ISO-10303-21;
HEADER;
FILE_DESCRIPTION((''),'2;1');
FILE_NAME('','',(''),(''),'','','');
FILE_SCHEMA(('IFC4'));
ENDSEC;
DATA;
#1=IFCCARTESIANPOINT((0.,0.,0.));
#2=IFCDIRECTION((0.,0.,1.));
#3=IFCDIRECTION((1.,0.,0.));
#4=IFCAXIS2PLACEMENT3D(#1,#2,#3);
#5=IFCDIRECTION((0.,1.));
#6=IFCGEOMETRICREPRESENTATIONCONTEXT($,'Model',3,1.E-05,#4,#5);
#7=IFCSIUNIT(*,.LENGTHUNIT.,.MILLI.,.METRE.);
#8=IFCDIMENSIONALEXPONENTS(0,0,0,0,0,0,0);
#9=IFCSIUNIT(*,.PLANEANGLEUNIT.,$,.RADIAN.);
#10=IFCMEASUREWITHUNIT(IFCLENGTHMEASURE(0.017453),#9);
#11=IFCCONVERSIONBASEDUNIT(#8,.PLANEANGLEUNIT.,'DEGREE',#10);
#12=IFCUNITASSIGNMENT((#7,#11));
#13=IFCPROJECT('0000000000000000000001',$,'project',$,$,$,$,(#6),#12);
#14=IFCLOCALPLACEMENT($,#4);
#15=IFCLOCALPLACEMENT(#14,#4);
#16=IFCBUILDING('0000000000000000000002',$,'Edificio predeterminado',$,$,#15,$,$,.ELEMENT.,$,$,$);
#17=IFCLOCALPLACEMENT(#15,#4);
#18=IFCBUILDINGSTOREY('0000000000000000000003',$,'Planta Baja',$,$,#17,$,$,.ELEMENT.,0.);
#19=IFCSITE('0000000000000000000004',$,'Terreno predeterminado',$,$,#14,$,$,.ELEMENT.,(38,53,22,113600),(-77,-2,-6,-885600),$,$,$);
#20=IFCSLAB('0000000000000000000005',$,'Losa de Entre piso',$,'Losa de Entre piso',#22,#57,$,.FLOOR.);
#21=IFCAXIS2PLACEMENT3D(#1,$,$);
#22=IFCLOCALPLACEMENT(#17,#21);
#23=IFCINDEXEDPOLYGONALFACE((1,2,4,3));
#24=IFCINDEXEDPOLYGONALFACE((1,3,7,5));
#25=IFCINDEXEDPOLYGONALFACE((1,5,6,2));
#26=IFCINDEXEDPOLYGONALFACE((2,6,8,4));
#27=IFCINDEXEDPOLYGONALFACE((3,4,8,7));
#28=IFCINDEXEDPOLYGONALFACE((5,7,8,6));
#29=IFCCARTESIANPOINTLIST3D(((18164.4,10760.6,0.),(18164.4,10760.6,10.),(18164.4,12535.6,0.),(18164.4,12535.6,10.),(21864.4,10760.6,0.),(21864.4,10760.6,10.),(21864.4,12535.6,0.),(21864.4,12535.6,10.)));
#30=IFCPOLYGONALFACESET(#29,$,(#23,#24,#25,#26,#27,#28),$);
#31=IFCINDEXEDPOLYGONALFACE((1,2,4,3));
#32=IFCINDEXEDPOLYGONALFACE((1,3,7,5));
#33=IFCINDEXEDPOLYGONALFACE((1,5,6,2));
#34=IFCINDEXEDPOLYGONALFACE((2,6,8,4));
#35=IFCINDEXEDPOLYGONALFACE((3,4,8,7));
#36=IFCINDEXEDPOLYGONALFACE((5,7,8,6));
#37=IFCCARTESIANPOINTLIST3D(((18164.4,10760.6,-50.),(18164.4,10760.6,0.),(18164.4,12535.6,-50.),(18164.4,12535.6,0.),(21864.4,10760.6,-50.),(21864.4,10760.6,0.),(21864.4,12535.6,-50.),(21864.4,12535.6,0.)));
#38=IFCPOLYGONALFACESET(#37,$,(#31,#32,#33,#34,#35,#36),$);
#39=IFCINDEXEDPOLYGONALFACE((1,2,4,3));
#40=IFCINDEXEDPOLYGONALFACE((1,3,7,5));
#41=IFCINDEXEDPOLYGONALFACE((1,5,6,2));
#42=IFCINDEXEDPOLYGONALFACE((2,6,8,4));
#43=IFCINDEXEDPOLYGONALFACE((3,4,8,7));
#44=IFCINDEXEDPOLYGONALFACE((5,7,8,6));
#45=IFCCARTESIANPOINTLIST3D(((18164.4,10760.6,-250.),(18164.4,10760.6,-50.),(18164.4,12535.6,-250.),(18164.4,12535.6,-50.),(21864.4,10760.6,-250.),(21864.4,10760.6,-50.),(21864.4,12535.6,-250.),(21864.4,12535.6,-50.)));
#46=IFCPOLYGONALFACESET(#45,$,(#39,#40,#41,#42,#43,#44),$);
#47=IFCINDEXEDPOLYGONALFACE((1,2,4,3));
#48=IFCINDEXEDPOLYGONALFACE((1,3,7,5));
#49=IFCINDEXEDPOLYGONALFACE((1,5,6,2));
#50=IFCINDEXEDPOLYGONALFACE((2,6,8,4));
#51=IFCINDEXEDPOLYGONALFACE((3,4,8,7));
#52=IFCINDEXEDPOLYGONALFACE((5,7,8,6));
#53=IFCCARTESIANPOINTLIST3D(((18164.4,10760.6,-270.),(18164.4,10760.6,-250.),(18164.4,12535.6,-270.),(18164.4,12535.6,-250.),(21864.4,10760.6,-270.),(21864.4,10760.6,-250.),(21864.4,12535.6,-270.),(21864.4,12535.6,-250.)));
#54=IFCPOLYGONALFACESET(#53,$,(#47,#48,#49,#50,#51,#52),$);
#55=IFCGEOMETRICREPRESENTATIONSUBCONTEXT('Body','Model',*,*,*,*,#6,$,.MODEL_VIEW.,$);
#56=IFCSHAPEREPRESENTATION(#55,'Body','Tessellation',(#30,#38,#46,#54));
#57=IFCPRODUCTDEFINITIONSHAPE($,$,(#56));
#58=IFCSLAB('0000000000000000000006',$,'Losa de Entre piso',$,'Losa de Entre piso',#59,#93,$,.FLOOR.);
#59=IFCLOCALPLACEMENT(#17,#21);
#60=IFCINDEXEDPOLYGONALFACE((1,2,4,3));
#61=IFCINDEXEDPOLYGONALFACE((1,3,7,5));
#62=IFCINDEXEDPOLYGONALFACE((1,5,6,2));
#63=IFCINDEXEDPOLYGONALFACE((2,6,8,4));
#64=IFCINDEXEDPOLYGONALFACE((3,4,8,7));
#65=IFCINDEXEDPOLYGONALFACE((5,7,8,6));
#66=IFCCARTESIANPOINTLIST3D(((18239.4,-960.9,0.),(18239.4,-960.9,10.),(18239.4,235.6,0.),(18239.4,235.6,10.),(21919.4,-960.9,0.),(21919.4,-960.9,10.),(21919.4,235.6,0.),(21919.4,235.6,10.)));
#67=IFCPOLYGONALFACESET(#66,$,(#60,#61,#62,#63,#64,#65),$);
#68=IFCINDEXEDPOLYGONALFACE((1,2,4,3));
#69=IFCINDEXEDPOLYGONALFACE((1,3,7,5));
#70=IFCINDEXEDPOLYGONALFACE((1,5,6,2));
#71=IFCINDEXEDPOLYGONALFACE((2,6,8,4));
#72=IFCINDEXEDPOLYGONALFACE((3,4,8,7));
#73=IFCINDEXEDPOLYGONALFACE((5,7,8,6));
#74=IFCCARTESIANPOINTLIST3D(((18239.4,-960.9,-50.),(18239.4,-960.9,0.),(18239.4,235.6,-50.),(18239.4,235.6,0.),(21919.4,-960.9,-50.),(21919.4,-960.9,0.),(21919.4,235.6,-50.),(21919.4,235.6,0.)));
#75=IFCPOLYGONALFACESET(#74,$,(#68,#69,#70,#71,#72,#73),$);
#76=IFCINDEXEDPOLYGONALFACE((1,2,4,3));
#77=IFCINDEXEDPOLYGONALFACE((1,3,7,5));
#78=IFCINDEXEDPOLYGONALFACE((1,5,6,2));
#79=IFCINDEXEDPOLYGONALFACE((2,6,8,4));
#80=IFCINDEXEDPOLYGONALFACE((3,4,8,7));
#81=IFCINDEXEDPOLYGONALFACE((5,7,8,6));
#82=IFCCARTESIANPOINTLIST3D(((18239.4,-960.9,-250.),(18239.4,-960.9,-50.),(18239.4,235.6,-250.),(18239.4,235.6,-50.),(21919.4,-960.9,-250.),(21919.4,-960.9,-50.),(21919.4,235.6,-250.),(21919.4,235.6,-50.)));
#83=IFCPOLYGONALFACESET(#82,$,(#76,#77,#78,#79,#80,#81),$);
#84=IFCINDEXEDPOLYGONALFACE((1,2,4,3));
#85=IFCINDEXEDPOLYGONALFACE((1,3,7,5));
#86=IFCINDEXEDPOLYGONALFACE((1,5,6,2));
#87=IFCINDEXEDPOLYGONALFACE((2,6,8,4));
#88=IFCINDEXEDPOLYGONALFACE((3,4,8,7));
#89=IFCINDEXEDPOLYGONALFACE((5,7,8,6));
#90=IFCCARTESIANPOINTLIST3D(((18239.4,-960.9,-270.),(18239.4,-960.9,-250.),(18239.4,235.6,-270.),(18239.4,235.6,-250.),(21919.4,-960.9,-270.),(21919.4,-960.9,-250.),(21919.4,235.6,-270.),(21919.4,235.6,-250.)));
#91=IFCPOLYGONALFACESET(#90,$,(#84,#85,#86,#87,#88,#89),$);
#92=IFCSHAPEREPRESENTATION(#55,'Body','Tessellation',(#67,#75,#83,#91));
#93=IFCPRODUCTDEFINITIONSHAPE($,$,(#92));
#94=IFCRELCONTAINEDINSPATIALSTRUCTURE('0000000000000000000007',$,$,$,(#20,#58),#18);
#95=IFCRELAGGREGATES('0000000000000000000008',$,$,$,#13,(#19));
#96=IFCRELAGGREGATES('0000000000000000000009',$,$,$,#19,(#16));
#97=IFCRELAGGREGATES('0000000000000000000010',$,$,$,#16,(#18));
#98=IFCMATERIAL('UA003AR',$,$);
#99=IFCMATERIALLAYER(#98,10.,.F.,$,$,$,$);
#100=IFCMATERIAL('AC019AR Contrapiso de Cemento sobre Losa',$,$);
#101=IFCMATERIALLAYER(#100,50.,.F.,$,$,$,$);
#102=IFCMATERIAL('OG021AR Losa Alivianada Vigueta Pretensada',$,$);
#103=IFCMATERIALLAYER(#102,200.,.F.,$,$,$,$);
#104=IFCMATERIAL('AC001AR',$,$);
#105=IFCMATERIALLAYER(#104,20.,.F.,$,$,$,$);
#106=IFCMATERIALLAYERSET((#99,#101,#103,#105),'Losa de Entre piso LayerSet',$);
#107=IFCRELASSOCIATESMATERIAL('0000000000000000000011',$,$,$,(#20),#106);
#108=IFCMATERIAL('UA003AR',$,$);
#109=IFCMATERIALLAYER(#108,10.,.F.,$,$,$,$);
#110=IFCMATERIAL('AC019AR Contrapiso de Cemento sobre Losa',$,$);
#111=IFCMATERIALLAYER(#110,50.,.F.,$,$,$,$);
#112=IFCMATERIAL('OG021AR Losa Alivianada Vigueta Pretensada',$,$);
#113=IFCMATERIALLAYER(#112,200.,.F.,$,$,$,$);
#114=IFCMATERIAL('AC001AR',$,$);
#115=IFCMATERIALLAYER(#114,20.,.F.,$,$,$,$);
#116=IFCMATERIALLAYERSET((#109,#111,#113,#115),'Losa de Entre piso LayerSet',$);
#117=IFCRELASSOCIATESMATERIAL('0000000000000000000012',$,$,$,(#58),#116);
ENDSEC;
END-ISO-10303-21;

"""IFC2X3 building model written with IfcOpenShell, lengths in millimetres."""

from ifc_helpers import new_model, entity, si_unit, converted_unit, direction, frame, origin_with_axes, place, context, subcontext, project, spatial, polyline, outline, extrude, material, layer, layer_set, layer_usage, element, save


model = new_model("IFC2X3")

# Units and contexts
model_context = context("Model", 3, precision=1e-05, world=origin_with_axes(), true_north=direction((0.0, 1.0)))
body_context = subcontext(model_context, "Body", "Model", "MODEL_VIEW")
ifc_project = project(units=[si_unit("LENGTHUNIT", "METRE", prefix="MILLI"), converted_unit("PLANEANGLEUNIT", "DEGREE", entity("IfcLengthMeasure", 0.017453), si_unit("PLANEANGLEUNIT", "RADIAN"), dimensions=[0, 0, 0, 0, 0, 0, 0])], contexts=[model_context])

# Site, building, storey
site_placement = place(None, origin_with_axes())
site = spatial("IfcSite", under=ifc_project, at=site_placement, Name="Terreno predeterminado", CompositionType="ELEMENT", RefLatitude=(38, 53, 22, 113600), RefLongitude=(-77, -2, -6, -885600))
building_placement = place(site_placement, origin_with_axes())
building = spatial("IfcBuilding", under=site, at=building_placement, Name="Edificio predeterminado", CompositionType="ELEMENT")
storey_placement = place(building_placement, origin_with_axes())
storey = spatial("IfcBuildingStorey", under=building, at=storey_placement, Name="Planta Baja", CompositionType="ELEMENT", Elevation=0.0)

# Slabs
ifc_material_1 = material(Name="UA003AR")
ifc_layer_1 = layer(ifc_material_1, 10.0, ventilated=False)
ifc_material_2 = material(Name="AC019AR Contrapiso de Cemento sobre Losa")
ifc_layer_2 = layer(ifc_material_2, 50.0, ventilated=False)
ifc_material_3 = material(Name="OG021AR Losa Alivianada Vigueta Pretensada")
ifc_layer_3 = layer(ifc_material_3, 200.0, ventilated=False)
ifc_material_4 = material(Name="AC001AR")
ifc_layer_4 = layer(ifc_material_4, 20.0, ventilated=False)
ifc_layer_set_1 = layer_set([ifc_layer_1, ifc_layer_2, ifc_layer_3, ifc_layer_4], Name="Losa de Entre piso LayerSet")
ifc_layer_usage_1 = layer_usage(ifc_layer_set_1, "AXIS3", "POSITIVE", 0.0)
slab_1_placement = place(storey_placement, origin_with_axes())
element("IfcSlab", 1, at=slab_1_placement, inside=storey, material=ifc_layer_usage_1, Name="Losa de Entre piso", ObjectType="Losa de Entre piso", PredefinedType="FLOOR", context=body_context, shape_type="SweptSolid", body=[
    extrude(outline(polyline([(0.0, 0.0), (1775.0, 0.0), (1775.0, 3700.0), (0.0, 3700.0), (0.0, 0.0)])), frame((21864.4, 12535.6, 0.0), z_axis=(0.0, 0.0, -1.0), x_axis=(0.0, -1.0, 0.0)), (0.0, 0.0, -1.0), 10.0),
    extrude(outline(polyline([(0.0, 0.0), (1775.0, 0.0), (1775.0, 3700.0), (0.0, 3700.0), (0.0, 0.0)])), frame((21864.4, 12535.6, -50.0), z_axis=(0.0, 0.0, -1.0), x_axis=(0.0, -1.0, 0.0)), (0.0, 0.0, -1.0), 50.0),
    extrude(outline(polyline([(0.0, 0.0), (1775.0, 0.0), (1775.0, 3700.0), (0.0, 3700.0), (0.0, 0.0)])), frame((21864.4, 12535.6, -250.0), z_axis=(0.0, 0.0, -1.0), x_axis=(0.0, -1.0, 0.0)), (0.0, 0.0, -1.0), 200.0),
    extrude(outline(polyline([(0.0, 0.0), (1775.0, 0.0), (1775.0, 3700.0), (0.0, 3700.0), (0.0, 0.0)])), frame((21864.4, 12535.6, -270.0), z_axis=(0.0, 0.0, -1.0), x_axis=(0.0, -1.0, 0.0)), (0.0, 0.0, -1.0), 20.0),
])
ifc_material_5 = material(Name="UA003AR")
ifc_layer_5 = layer(ifc_material_5, 10.0, ventilated=False)
ifc_material_6 = material(Name="AC019AR Contrapiso de Cemento sobre Losa")
ifc_layer_6 = layer(ifc_material_6, 50.0, ventilated=False)
ifc_material_7 = material(Name="OG021AR Losa Alivianada Vigueta Pretensada")
ifc_layer_7 = layer(ifc_material_7, 200.0, ventilated=False)
ifc_material_8 = material(Name="AC001AR")
ifc_layer_8 = layer(ifc_material_8, 20.0, ventilated=False)
ifc_layer_set_2 = layer_set([ifc_layer_5, ifc_layer_6, ifc_layer_7, ifc_layer_8], Name="Losa de Entre piso LayerSet")
ifc_layer_usage_2 = layer_usage(ifc_layer_set_2, "AXIS3", "POSITIVE", 0.0)
slab_2_placement = place(storey_placement, origin_with_axes())
element("IfcSlab", 2, at=slab_2_placement, inside=storey, material=ifc_layer_usage_2, Name="Losa de Entre piso", ObjectType="Losa de Entre piso", PredefinedType="FLOOR", context=body_context, shape_type="SweptSolid", body=[
    extrude(outline(polyline([(0.0, 0.0), (1196.6, 0.0), (1196.6, 3680.0), (0.0, 3680.0), (0.0, 0.0)])), frame((21919.4, 235.6, 0.0), z_axis=(0.0, 0.0, -1.0), x_axis=(0.0, -1.0, 0.0)), (0.0, 0.0, -1.0), 10.0),
    extrude(outline(polyline([(0.0, 0.0), (1196.6, 0.0), (1196.6, 3680.0), (0.0, 3680.0), (0.0, 0.0)])), frame((21919.4, 235.6, -50.0), z_axis=(0.0, 0.0, -1.0), x_axis=(0.0, -1.0, 0.0)), (0.0, 0.0, -1.0), 50.0),
    extrude(outline(polyline([(0.0, 0.0), (1196.6, 0.0), (1196.6, 3680.0), (0.0, 3680.0), (0.0, 0.0)])), frame((21919.4, 235.6, -250.0), z_axis=(0.0, 0.0, -1.0), x_axis=(0.0, -1.0, 0.0)), (0.0, 0.0, -1.0), 200.0),
    extrude(outline(polyline([(0.0, 0.0), (1196.6, 0.0), (1196.6, 3680.0), (0.0, 3680.0), (0.0, 0.0)])), frame((21919.4, 235.6, -270.0), z_axis=(0.0, 0.0, -1.0), x_axis=(0.0, -1.0, 0.0)), (0.0, 0.0, -1.0), 20.0),
])

save(model, "model.ifc")
